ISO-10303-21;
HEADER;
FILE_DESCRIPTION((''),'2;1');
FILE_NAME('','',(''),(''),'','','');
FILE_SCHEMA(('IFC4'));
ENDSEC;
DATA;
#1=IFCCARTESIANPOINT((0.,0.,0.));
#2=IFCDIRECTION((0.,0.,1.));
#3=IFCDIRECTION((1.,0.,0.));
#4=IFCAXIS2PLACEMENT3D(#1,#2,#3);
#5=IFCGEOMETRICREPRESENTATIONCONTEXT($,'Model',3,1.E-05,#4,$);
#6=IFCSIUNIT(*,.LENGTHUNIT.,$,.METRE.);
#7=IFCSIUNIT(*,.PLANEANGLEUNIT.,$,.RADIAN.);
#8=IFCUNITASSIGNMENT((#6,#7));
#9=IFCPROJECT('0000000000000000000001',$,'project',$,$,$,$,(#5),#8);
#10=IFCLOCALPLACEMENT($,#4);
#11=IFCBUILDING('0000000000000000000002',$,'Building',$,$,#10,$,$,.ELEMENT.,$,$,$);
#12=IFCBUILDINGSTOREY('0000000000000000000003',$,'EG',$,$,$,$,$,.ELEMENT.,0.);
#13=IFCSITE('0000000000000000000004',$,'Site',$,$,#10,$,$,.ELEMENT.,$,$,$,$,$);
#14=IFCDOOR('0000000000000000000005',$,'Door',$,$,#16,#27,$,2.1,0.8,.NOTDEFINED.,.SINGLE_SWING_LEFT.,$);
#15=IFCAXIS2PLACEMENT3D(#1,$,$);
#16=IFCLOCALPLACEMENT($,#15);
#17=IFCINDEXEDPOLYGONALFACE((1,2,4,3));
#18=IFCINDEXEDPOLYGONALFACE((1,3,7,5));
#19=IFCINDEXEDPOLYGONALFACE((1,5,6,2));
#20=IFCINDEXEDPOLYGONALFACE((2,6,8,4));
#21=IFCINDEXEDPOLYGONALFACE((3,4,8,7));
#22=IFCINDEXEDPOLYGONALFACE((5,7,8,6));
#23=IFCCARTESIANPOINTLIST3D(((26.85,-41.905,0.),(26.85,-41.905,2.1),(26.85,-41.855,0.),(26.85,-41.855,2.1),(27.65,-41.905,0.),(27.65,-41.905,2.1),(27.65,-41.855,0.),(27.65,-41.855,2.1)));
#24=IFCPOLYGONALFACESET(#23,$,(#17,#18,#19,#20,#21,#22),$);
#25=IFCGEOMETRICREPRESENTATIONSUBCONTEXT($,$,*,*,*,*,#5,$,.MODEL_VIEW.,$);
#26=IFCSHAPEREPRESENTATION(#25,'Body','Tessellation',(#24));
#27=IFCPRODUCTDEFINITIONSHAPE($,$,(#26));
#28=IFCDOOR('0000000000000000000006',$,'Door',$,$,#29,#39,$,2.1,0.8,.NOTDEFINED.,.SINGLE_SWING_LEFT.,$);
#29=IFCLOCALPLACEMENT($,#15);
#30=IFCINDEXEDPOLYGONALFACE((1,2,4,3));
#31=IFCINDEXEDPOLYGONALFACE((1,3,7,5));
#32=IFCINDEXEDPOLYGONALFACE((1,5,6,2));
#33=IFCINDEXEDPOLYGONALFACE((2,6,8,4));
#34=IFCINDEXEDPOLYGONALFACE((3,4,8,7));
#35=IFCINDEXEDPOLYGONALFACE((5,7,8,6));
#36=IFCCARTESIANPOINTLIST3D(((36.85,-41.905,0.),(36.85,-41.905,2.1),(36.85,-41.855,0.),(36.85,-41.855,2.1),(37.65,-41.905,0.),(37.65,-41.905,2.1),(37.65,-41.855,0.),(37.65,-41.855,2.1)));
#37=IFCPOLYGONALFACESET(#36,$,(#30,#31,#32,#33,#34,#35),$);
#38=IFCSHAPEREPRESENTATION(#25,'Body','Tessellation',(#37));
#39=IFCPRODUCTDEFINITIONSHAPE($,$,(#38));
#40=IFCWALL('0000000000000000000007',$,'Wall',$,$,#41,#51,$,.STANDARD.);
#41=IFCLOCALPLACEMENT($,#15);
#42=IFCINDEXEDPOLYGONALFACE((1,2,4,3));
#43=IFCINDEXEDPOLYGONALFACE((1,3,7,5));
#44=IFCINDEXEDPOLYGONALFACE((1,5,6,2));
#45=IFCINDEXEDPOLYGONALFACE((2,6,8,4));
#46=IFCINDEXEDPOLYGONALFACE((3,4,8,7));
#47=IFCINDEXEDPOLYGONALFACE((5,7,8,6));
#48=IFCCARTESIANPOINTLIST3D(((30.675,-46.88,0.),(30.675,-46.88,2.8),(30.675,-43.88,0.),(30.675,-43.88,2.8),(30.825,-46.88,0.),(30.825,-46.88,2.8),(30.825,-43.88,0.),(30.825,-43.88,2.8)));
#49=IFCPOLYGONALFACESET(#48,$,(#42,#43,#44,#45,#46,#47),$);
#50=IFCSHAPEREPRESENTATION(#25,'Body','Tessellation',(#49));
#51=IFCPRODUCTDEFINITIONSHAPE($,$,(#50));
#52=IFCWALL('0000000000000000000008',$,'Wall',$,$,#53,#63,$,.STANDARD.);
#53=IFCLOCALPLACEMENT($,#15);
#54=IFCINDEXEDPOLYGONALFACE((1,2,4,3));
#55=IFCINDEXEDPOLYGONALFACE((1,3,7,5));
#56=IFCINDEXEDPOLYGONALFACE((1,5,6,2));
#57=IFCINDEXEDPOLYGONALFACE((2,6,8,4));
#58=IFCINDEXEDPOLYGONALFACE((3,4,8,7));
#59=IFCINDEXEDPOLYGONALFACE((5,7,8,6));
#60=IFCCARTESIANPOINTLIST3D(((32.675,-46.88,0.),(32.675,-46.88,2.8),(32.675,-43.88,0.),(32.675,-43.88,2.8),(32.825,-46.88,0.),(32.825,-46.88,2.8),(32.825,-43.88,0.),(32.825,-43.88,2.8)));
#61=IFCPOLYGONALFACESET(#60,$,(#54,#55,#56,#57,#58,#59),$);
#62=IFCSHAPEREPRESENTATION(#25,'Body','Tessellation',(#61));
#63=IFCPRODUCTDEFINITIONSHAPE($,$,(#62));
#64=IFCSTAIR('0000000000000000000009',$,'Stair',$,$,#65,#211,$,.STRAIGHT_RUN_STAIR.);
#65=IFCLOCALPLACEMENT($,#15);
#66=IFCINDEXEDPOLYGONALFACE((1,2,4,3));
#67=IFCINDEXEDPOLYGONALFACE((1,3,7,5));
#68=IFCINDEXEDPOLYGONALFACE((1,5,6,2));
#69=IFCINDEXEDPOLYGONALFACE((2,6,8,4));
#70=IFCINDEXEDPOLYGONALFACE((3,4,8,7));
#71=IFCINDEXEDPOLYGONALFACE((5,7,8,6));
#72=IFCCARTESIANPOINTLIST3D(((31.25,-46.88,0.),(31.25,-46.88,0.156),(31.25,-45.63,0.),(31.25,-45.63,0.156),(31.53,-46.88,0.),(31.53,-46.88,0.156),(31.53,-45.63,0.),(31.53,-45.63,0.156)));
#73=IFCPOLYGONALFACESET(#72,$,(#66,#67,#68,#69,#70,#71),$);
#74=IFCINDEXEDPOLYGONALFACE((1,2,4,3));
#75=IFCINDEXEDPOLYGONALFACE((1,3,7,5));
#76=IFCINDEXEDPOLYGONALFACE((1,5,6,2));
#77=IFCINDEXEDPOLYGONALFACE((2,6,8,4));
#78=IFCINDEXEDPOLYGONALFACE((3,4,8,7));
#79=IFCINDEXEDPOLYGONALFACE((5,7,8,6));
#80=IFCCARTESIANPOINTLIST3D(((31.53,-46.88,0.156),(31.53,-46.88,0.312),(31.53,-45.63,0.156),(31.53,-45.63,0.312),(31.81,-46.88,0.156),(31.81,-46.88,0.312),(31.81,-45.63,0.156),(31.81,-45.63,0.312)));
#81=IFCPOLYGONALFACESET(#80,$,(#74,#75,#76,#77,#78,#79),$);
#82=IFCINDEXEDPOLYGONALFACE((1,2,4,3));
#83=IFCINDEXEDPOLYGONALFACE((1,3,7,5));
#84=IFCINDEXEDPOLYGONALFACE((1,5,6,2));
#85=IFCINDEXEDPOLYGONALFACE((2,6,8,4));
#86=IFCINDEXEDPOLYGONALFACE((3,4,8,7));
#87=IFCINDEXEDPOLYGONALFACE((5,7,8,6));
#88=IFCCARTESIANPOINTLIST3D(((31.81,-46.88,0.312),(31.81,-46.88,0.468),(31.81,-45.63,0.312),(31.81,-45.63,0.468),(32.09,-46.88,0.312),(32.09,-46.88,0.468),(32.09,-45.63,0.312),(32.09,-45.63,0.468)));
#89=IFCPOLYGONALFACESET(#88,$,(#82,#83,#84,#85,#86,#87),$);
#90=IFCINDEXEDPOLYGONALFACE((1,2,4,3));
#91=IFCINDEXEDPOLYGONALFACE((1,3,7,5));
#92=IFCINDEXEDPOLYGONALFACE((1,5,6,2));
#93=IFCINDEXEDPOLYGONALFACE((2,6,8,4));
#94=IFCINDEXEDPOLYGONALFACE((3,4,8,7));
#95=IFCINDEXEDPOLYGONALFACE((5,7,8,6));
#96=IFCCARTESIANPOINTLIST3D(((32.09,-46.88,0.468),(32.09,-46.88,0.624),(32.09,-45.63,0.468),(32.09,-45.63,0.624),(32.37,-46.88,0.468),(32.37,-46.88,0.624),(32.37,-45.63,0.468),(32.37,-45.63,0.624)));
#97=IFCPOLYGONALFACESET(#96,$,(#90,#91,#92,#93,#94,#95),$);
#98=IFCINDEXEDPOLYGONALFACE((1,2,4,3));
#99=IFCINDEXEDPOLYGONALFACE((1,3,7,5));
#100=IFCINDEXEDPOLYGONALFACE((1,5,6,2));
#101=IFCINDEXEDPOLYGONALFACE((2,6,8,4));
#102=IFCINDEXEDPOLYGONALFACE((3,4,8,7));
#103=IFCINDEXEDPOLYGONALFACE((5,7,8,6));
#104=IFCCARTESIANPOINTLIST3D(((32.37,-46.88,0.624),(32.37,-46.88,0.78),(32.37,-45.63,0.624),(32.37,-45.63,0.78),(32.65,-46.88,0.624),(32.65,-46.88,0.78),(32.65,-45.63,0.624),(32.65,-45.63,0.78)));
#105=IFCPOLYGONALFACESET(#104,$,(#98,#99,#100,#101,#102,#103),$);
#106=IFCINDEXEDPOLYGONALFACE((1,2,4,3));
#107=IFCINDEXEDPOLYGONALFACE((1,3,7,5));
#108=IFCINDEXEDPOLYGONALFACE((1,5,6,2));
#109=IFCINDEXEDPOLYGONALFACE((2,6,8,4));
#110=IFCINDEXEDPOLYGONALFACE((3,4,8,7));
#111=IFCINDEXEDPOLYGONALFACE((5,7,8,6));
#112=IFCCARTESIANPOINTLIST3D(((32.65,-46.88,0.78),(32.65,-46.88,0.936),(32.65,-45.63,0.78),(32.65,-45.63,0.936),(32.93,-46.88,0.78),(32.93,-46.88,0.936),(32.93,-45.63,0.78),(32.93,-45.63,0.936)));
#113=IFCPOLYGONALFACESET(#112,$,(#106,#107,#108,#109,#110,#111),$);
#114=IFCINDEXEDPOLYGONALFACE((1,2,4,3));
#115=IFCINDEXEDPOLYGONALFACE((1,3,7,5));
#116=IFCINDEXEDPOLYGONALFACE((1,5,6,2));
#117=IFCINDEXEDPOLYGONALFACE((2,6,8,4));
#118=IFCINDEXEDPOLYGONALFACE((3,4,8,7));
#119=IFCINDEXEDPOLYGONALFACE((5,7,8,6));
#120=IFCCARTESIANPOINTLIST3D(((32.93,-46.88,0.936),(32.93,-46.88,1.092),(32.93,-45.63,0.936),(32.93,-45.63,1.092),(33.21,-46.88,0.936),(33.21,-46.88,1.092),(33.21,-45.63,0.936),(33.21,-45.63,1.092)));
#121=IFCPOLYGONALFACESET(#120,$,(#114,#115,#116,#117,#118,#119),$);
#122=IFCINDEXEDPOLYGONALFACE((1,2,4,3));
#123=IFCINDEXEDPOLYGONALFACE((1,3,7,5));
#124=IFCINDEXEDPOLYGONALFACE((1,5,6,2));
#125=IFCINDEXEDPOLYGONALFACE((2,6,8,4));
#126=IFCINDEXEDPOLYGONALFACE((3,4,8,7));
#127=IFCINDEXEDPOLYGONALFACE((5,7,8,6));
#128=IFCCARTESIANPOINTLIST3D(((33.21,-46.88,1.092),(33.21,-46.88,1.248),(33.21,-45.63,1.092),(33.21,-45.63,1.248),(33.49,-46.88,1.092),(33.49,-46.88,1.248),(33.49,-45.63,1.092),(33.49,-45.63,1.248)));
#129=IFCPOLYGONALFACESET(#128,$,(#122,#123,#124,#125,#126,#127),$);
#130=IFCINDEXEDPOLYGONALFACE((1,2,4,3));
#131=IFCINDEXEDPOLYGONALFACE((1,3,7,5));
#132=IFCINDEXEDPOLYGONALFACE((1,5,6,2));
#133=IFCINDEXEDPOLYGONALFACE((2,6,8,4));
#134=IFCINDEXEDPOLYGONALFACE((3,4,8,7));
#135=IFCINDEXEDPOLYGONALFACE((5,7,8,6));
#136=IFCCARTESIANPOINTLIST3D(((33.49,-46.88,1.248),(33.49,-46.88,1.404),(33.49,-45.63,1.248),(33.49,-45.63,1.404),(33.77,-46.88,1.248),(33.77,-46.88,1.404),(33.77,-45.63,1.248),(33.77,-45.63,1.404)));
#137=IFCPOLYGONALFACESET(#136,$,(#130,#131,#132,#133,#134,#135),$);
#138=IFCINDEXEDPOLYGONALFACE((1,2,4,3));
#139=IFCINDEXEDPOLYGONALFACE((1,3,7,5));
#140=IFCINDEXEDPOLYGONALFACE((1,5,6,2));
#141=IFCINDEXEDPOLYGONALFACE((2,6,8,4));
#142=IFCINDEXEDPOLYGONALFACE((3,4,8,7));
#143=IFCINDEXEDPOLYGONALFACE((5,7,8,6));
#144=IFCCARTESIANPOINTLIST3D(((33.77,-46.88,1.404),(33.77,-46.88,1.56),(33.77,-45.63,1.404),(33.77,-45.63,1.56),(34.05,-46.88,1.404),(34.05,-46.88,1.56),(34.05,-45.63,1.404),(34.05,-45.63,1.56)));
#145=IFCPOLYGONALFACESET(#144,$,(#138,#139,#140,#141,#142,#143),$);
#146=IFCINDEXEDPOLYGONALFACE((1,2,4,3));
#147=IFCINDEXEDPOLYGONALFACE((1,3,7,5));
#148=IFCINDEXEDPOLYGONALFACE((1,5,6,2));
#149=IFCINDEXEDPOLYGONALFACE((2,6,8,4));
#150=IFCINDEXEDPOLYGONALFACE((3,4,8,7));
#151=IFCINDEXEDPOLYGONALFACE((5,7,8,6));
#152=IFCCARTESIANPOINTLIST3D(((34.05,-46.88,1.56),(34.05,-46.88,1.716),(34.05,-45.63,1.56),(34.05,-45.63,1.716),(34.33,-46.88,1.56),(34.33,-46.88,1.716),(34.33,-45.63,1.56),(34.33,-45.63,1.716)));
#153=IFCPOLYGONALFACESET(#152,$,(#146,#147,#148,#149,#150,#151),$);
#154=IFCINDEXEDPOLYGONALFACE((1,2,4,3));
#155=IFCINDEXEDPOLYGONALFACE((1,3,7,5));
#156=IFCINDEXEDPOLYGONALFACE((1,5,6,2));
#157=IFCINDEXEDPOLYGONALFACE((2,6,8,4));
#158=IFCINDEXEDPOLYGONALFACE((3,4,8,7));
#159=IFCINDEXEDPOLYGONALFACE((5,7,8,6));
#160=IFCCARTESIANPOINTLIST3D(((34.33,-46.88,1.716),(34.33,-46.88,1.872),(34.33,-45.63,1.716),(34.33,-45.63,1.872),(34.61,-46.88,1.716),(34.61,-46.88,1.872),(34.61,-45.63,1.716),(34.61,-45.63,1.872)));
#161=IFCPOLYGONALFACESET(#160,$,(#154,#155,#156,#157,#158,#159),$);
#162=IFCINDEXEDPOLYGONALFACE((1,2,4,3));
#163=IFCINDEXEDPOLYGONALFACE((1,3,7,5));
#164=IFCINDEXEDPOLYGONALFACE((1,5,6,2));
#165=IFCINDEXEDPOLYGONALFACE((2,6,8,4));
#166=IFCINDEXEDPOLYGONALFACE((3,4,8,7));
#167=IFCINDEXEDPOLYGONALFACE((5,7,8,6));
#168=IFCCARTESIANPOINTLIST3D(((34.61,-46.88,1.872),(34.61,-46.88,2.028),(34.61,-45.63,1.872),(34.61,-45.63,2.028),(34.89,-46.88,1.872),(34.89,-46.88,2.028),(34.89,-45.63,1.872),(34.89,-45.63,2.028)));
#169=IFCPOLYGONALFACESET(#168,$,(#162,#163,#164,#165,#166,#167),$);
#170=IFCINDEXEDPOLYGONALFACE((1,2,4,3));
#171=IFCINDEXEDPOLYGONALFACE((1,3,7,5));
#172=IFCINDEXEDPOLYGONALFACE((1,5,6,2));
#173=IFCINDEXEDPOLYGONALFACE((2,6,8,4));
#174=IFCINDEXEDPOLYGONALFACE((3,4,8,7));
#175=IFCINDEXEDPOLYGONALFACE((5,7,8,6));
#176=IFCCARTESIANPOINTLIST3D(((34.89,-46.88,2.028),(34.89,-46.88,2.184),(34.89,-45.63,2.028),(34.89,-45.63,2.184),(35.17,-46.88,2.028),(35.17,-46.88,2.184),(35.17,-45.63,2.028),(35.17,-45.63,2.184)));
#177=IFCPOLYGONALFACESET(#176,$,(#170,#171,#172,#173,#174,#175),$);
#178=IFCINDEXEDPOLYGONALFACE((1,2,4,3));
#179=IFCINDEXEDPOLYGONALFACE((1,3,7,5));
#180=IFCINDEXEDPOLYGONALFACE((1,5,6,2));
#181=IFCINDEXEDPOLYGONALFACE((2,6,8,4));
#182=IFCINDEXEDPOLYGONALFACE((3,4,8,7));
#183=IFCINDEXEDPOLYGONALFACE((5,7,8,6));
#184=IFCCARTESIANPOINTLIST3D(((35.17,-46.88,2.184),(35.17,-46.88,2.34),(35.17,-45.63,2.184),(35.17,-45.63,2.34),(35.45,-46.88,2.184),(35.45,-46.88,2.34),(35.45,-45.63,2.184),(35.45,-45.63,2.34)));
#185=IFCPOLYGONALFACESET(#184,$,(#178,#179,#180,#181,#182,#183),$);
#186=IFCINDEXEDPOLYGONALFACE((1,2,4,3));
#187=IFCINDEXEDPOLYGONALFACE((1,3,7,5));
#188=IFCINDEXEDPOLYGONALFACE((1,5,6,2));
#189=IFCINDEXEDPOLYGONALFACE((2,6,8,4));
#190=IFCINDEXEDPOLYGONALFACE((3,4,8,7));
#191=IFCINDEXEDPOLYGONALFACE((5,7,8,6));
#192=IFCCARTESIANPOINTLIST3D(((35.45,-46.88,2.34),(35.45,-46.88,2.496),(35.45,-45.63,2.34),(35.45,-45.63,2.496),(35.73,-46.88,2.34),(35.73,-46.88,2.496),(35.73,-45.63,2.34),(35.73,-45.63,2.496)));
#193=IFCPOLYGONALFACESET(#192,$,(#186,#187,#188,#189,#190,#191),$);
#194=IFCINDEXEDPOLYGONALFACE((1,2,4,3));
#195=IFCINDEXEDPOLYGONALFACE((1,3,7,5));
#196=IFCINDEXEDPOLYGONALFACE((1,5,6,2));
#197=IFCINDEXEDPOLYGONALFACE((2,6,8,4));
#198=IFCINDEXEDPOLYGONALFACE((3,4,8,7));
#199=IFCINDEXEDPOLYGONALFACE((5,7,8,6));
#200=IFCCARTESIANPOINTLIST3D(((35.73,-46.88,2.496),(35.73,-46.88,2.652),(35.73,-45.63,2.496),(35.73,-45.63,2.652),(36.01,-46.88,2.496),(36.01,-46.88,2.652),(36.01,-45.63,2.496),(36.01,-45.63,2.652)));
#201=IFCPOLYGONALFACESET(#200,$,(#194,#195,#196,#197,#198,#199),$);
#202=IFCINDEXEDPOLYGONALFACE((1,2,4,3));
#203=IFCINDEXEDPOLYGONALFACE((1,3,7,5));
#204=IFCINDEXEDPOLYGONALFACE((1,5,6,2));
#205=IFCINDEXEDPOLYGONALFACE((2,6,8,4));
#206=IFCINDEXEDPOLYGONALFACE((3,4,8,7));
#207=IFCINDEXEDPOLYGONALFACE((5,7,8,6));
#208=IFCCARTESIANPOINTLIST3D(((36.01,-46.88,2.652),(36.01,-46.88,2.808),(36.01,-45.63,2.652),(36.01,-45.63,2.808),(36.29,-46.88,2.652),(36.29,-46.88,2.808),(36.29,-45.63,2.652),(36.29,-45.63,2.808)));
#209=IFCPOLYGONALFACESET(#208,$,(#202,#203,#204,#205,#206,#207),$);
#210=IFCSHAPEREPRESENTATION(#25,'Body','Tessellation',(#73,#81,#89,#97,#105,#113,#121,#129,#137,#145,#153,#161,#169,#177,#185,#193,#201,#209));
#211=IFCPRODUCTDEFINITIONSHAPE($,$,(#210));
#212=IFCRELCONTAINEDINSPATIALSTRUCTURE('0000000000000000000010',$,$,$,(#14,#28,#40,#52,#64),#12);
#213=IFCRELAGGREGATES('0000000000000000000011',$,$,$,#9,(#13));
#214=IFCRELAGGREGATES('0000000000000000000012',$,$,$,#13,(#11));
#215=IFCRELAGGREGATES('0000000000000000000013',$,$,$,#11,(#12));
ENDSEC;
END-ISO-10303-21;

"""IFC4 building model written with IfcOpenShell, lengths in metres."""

from ifc_helpers import new_model, si_unit, frame, frame_2d, origin, origin_with_axes, origin_2d, place, context, subcontext, project, spatial, rectangle, extrude, element, save


model = new_model("IFC4")

# Units and contexts
model_context = context("Model", 3, precision=1e-05, world=origin_with_axes())
sub_context = subcontext(model_context, None, None, "MODEL_VIEW")
ifc_project = project(units=[si_unit("LENGTHUNIT", "METRE"), si_unit("PLANEANGLEUNIT", "RADIAN")], contexts=[model_context])

# Site, building, storey
placement_1 = place(None, origin_with_axes())
site = spatial("IfcSite", under=ifc_project, at=placement_1, Name="Site", CompositionType="ELEMENT")
building = spatial("IfcBuilding", under=site, at=placement_1, Name="Building", CompositionType="ELEMENT")
storey = spatial("IfcBuildingStorey", under=building, Name="EG", CompositionType="ELEMENT", Elevation=0.0)

# Shared definitions
placement_2 = place(placement_1, origin())

# Doors
for number, where, name in (
    (1, (27.25, -41.88, 0.0), "Door"),
    (2, (37.25, -41.88, 0.0), "Door"),
):
    element("IfcDoor", number, at=place(placement_1, frame(where)), inside=storey, Name=name, OperationType="SINGLE_SWING_LEFT", OverallHeight=2.1, OverallWidth=0.8, PredefinedType="NOTDEFINED", context=sub_context, shape_type="SweptSolid", body=[
        extrude(rectangle(XDim=0.8, YDim=0.05, at=origin_2d()), origin(), (0.0, 0.0, 1.0), 2.1),
    ])

# Walls
for number, where, x_axis, name in (
    (3, (30.75, -46.88, 0.0), (0.0, 1.0, 0.0), "Wall"),
    (4, (32.75, -46.88, 0.0), (0.0, 1.0, 0.0), "Wall"),
):
    element("IfcWall", number, at=place(placement_2, frame(where, x_axis=x_axis)), inside=storey, Name=name, PredefinedType="STANDARD", context=sub_context, shape_type="SweptSolid", body=[
        extrude(rectangle(XDim=3.0, YDim=0.15, at=frame_2d((1.5, 0.0))), origin(), (0.0, 0.0, 1.0), 2.8),
    ])

# Stair
stair_placement = place(placement_2, frame((31.25, -46.88, 0.0)))
element("IfcStair", 5, at=stair_placement, inside=storey, Name="Stair", PredefinedType="STRAIGHT_RUN_STAIR", context=sub_context, shape_type="SolidModel", body=[
    extrude(rectangle(XDim=0.28, YDim=1.25, at=frame_2d((0.14, 0.625))), origin(), (0.0, 0.0, 1.0), 0.156),
    extrude(rectangle(XDim=0.28, YDim=1.25, at=frame_2d((0.14, 0.625))), frame((0.28, 0.0, 0.156)), (0.0, 0.0, 1.0), 0.156),
    extrude(rectangle(XDim=0.28, YDim=1.25, at=frame_2d((0.14, 0.625))), frame((0.56, 0.0, 0.312)), (0.0, 0.0, 1.0), 0.156),
    extrude(rectangle(XDim=0.28, YDim=1.25, at=frame_2d((0.14, 0.625))), frame((0.84, 0.0, 0.468)), (0.0, 0.0, 1.0), 0.156),
    extrude(rectangle(XDim=0.28, YDim=1.25, at=frame_2d((0.14, 0.625))), frame((1.12, 0.0, 0.624)), (0.0, 0.0, 1.0), 0.156),
    extrude(rectangle(XDim=0.28, YDim=1.25, at=frame_2d((0.14, 0.625))), frame((1.4, 0.0, 0.78)), (0.0, 0.0, 1.0), 0.156),
    extrude(rectangle(XDim=0.28, YDim=1.25, at=frame_2d((0.14, 0.625))), frame((1.68, 0.0, 0.936)), (0.0, 0.0, 1.0), 0.156),
    extrude(rectangle(XDim=0.28, YDim=1.25, at=frame_2d((0.14, 0.625))), frame((1.96, 0.0, 1.092)), (0.0, 0.0, 1.0), 0.156),
    extrude(rectangle(XDim=0.28, YDim=1.25, at=frame_2d((0.14, 0.625))), frame((2.24, 0.0, 1.248)), (0.0, 0.0, 1.0), 0.156),
    extrude(rectangle(XDim=0.28, YDim=1.25, at=frame_2d((0.14, 0.625))), frame((2.52, 0.0, 1.404)), (0.0, 0.0, 1.0), 0.156),
    extrude(rectangle(XDim=0.28, YDim=1.25, at=frame_2d((0.14, 0.625))), frame((2.8, 0.0, 1.56)), (0.0, 0.0, 1.0), 0.156),
    extrude(rectangle(XDim=0.28, YDim=1.25, at=frame_2d((0.14, 0.625))), frame((3.08, 0.0, 1.716)), (0.0, 0.0, 1.0), 0.156),
    extrude(rectangle(XDim=0.28, YDim=1.25, at=frame_2d((0.14, 0.625))), frame((3.36, 0.0, 1.872)), (0.0, 0.0, 1.0), 0.156),
    extrude(rectangle(XDim=0.28, YDim=1.25, at=frame_2d((0.14, 0.625))), frame((3.64, 0.0, 2.028)), (0.0, 0.0, 1.0), 0.156),
    extrude(rectangle(XDim=0.28, YDim=1.25, at=frame_2d((0.14, 0.625))), frame((3.92, 0.0, 2.184)), (0.0, 0.0, 1.0), 0.156),
    extrude(rectangle(XDim=0.28, YDim=1.25, at=frame_2d((0.14, 0.625))), frame((4.2, 0.0, 2.34)), (0.0, 0.0, 1.0), 0.156),
    extrude(rectangle(XDim=0.28, YDim=1.25, at=frame_2d((0.14, 0.625))), frame((4.48, 0.0, 2.496)), (0.0, 0.0, 1.0), 0.156),
    extrude(rectangle(XDim=0.28, YDim=1.25, at=frame_2d((0.14, 0.625))), frame((4.76, 0.0, 2.652)), (0.0, 0.0, 1.0), 0.156),
])

save(model, "model.ifc")
